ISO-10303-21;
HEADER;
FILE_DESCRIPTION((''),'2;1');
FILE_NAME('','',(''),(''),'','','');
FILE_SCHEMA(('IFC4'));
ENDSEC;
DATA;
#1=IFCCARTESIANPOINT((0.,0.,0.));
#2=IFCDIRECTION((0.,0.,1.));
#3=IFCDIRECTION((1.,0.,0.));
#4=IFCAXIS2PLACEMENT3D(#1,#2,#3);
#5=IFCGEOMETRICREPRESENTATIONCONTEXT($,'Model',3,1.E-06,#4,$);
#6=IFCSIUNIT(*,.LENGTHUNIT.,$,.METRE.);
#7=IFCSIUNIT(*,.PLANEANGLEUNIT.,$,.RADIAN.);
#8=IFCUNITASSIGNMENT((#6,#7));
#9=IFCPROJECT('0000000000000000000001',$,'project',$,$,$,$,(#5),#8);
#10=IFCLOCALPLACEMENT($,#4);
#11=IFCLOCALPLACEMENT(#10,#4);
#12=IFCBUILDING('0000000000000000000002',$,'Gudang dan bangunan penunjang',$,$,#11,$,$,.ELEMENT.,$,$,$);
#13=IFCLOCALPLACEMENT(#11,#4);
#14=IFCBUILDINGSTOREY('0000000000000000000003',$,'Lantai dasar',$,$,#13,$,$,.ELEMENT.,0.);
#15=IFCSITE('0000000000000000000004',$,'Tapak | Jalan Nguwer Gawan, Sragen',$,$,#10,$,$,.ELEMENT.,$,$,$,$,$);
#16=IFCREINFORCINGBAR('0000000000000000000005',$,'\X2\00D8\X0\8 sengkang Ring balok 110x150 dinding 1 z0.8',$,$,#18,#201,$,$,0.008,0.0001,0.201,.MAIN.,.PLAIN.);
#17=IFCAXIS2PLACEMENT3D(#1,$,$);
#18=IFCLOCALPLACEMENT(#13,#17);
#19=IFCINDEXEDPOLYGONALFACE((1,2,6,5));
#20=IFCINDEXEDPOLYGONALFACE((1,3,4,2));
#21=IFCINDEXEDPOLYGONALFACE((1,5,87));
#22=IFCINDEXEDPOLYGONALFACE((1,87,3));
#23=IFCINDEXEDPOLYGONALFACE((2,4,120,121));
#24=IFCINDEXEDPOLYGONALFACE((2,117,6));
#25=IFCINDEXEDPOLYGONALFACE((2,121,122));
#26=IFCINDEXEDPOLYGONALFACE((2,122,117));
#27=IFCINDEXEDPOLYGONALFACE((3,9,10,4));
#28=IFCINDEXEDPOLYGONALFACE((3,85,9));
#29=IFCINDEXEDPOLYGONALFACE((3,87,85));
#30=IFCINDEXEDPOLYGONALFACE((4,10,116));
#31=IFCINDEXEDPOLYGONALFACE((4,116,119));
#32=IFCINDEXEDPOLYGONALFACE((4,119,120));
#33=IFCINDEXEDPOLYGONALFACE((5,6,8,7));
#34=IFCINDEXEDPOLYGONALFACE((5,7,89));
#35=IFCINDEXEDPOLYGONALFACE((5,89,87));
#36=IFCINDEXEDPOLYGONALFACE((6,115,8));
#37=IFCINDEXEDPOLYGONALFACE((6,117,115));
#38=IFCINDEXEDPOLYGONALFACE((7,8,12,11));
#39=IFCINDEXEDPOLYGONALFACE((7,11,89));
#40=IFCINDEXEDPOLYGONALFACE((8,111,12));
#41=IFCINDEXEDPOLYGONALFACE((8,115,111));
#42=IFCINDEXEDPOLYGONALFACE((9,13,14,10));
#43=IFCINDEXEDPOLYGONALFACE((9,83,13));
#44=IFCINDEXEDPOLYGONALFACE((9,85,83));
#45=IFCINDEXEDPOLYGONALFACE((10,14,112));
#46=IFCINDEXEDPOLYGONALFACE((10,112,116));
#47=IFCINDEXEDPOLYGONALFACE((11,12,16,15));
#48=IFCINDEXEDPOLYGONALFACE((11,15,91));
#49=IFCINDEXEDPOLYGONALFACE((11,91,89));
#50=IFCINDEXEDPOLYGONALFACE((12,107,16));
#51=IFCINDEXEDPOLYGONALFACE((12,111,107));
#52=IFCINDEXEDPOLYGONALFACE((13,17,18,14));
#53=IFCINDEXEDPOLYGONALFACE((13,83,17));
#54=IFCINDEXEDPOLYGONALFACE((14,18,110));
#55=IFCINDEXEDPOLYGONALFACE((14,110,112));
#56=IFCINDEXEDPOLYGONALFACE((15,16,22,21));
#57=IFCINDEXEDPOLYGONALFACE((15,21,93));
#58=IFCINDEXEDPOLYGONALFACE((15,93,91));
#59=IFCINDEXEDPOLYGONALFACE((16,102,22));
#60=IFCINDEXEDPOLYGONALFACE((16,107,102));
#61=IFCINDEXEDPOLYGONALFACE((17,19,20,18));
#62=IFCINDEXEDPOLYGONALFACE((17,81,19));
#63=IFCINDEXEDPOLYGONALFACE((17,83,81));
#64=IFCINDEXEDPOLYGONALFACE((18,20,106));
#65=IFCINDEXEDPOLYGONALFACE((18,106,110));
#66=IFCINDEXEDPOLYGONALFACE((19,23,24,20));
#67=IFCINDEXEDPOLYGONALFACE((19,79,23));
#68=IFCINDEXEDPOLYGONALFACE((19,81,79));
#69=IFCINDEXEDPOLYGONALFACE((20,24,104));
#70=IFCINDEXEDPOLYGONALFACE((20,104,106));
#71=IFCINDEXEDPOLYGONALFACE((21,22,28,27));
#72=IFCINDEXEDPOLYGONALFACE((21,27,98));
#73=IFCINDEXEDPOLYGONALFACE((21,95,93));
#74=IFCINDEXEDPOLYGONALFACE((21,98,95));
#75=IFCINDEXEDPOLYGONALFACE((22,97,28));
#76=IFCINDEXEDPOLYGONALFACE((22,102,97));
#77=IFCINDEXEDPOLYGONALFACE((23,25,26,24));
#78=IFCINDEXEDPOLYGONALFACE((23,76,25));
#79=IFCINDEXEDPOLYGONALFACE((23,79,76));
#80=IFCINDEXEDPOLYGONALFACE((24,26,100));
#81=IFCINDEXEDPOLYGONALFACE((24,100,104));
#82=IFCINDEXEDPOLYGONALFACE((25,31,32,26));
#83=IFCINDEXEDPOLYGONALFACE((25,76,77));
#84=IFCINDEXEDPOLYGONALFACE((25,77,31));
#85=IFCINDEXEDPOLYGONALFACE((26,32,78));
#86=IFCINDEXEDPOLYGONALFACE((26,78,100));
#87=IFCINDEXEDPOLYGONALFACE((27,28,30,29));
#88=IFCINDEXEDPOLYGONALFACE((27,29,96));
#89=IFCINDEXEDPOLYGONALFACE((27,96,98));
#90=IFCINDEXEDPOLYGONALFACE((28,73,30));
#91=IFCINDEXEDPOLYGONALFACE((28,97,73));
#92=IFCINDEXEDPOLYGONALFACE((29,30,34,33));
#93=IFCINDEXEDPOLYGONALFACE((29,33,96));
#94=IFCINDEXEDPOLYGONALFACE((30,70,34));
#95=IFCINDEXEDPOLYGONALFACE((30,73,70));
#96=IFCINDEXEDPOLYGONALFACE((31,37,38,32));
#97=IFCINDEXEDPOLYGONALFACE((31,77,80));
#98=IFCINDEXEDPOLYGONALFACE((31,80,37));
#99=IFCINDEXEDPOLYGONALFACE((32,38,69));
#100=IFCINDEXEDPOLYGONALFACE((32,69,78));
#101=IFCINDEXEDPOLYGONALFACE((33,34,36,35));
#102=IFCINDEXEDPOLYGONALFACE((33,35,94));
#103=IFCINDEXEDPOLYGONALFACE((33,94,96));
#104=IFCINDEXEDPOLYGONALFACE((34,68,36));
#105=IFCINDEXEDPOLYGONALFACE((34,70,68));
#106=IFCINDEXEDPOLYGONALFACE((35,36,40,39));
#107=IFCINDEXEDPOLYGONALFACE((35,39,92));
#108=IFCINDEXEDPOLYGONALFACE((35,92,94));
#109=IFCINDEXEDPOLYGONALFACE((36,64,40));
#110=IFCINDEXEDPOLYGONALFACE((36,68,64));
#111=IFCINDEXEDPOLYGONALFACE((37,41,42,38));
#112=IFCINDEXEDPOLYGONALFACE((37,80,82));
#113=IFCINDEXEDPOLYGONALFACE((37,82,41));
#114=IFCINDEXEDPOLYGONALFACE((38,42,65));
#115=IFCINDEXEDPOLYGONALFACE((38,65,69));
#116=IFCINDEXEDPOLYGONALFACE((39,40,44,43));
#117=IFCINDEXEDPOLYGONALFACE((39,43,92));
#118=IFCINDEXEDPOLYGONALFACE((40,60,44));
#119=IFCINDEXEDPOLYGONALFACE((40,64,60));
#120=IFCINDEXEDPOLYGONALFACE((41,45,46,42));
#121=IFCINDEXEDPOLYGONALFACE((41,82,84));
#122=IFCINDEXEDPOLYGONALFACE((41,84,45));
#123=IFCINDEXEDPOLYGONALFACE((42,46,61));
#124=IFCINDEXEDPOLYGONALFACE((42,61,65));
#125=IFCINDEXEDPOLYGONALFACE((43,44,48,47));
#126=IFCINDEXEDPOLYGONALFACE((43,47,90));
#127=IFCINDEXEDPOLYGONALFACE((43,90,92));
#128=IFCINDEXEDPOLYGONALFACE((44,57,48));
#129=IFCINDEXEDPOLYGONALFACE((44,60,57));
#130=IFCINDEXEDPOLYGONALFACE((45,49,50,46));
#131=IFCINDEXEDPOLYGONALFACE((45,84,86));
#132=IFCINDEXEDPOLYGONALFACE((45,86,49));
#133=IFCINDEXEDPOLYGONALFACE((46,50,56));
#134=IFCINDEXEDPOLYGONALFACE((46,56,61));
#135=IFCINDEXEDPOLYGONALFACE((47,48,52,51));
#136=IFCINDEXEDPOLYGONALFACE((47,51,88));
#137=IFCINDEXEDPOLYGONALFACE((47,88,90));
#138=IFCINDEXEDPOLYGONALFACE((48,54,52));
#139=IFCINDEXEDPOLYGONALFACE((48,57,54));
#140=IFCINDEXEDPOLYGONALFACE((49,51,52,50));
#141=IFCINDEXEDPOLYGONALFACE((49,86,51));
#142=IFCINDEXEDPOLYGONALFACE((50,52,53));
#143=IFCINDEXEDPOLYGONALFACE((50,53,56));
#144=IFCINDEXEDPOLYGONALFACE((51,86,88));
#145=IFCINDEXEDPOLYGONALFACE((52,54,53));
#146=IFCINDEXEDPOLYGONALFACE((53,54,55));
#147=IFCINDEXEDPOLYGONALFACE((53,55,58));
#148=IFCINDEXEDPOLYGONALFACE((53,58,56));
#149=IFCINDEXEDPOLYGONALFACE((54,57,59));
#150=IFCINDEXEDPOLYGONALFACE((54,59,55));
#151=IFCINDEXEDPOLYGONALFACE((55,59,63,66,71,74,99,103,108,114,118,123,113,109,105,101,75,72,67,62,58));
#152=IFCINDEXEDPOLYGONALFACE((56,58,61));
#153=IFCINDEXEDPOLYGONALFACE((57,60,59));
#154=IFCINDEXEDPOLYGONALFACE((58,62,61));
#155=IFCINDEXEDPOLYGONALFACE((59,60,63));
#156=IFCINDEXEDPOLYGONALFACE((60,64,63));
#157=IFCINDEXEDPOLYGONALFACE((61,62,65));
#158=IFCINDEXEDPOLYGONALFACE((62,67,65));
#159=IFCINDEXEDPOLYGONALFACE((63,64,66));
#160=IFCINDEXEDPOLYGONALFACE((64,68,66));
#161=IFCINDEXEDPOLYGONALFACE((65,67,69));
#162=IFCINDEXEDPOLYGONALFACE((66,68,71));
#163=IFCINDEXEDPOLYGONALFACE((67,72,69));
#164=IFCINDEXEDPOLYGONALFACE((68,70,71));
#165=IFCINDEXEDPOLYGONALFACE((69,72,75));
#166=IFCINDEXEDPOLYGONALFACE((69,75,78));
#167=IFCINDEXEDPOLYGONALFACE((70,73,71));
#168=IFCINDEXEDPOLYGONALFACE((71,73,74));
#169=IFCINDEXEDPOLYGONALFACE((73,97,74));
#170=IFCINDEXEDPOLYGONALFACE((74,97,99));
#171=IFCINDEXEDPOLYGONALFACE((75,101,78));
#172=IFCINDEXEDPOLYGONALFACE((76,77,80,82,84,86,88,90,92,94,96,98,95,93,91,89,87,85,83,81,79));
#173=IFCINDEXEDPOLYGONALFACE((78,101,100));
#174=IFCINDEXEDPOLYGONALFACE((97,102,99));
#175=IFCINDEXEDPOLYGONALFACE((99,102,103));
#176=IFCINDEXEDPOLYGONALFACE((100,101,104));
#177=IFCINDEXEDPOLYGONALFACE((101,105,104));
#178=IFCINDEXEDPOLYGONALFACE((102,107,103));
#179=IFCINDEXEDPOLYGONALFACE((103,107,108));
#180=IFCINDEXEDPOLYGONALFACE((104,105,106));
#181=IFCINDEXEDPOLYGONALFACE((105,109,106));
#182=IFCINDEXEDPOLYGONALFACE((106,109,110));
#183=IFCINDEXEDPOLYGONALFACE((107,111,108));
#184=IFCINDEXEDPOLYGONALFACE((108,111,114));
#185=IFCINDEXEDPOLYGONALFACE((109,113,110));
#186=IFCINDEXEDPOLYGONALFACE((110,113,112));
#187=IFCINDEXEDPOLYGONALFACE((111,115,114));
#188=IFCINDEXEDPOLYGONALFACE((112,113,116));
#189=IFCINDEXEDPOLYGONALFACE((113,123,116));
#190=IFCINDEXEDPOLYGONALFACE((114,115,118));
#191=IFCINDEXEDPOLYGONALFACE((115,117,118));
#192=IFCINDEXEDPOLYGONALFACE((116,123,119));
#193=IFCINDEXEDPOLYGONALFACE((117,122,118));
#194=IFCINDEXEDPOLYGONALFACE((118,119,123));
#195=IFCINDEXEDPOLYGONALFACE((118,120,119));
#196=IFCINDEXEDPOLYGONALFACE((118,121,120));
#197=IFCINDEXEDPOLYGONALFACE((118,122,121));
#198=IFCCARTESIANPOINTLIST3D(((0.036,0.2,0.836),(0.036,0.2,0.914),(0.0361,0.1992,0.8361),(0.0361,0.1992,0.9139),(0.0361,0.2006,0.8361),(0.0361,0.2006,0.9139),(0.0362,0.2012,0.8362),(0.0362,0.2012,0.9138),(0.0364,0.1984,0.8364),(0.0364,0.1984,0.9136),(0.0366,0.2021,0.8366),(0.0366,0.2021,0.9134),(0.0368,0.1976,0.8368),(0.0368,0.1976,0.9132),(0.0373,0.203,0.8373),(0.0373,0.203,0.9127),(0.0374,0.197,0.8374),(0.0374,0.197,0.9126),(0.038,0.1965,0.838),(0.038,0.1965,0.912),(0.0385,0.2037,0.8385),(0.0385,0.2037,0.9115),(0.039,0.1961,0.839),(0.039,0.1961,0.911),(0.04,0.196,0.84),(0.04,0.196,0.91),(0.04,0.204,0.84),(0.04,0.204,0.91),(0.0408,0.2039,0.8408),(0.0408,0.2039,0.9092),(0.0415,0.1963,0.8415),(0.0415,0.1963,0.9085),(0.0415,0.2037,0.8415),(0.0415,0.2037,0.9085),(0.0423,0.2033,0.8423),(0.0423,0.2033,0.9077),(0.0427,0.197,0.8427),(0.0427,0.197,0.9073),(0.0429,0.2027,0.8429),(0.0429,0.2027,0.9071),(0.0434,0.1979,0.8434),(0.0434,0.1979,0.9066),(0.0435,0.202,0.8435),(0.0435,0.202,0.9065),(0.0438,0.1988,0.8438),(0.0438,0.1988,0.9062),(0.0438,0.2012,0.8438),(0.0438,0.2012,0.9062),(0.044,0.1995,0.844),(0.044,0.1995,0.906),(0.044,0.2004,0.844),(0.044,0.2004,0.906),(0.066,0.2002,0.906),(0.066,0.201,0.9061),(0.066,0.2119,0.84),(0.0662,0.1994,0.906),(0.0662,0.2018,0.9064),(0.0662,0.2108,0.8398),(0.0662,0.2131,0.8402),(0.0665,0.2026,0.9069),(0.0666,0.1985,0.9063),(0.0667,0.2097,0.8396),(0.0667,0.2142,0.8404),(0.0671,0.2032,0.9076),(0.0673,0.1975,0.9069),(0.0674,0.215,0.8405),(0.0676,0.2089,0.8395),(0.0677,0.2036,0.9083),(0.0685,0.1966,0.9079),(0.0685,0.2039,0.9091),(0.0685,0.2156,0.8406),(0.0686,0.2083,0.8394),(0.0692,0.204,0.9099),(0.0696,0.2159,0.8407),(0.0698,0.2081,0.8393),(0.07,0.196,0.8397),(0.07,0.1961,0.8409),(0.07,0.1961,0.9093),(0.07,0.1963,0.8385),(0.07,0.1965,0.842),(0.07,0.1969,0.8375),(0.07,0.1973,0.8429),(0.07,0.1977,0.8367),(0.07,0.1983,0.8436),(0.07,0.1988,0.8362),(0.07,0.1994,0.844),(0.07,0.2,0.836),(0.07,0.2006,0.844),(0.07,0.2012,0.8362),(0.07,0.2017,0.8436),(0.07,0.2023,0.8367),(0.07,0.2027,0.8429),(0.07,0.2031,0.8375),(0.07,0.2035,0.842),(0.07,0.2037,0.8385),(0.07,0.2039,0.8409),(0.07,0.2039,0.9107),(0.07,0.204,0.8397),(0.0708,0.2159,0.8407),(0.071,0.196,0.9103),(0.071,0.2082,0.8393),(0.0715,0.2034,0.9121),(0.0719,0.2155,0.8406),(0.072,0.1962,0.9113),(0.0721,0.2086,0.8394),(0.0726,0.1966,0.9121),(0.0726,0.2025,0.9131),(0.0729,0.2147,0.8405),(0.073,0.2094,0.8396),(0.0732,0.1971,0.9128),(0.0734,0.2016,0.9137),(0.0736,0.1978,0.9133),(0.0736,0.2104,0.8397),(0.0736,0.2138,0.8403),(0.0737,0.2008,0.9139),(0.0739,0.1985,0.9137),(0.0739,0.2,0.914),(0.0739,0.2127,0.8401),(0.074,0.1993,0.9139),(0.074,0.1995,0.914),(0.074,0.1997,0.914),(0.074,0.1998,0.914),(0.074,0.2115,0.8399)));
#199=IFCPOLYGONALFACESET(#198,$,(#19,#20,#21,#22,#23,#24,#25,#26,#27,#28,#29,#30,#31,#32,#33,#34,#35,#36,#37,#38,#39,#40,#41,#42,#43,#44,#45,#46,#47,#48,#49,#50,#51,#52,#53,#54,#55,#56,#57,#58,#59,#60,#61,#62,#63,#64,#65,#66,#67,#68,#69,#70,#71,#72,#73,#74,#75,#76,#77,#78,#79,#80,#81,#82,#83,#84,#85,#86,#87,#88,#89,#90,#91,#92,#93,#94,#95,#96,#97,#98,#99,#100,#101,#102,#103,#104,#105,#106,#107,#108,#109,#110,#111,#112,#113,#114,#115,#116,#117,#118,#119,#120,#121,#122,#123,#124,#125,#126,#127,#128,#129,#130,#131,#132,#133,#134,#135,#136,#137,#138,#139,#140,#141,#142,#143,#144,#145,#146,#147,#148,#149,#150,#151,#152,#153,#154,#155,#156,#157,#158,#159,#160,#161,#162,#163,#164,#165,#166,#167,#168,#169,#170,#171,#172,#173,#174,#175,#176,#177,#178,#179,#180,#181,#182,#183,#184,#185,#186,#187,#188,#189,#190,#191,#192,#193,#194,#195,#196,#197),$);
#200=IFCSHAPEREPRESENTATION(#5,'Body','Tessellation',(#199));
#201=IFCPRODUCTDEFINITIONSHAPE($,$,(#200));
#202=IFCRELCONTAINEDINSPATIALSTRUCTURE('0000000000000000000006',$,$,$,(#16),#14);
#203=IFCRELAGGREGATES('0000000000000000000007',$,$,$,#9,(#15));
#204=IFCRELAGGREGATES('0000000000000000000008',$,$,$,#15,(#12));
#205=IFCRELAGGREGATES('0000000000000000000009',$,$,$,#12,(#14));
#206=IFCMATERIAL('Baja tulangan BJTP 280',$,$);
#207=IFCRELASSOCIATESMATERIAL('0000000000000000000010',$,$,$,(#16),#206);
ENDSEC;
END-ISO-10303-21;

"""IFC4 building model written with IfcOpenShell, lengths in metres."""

from ifc_helpers import new_model, entity, si_unit, origin_with_axes, place, context, project, spatial, material, element, save


model = new_model("IFC4")

# Units and contexts
model_context = context("Model", 3, precision=1e-06, world=origin_with_axes())
ifc_project = project(units=[si_unit("LENGTHUNIT", "METRE"), si_unit("PLANEANGLEUNIT", "RADIAN")], contexts=[model_context])

# Site, building, storey
site_placement = place(None, origin_with_axes())
site = spatial("IfcSite", under=ifc_project, at=site_placement, Name="Tapak | Jalan Nguwer Gawan, Sragen", CompositionType="ELEMENT")
building_placement = place(site_placement, origin_with_axes())
building = spatial("IfcBuilding", under=site, at=building_placement, Name="Gudang dan bangunan penunjang", CompositionType="ELEMENT")
storey_placement = place(building_placement, origin_with_axes())
storey = spatial("IfcBuildingStorey", under=building, at=storey_placement, Name="Lantai dasar", CompositionType="ELEMENT", Elevation=0.0)

# Shared definitions
placement = place(None, origin_with_axes())

# Reinforcing bar
ifc_material_1 = material(Name="Baja tulangan BJTP 280")
element("IfcReinforcingBar", 1, at=placement, inside=storey, material=ifc_material_1, Name="Ø8 sengkang Ring balok 110x150 dinding 1 z0.8", BarLength=0.201, BarSurface="PLAIN", CrossSectionArea=0.0001, NominalDiameter=0.008, PredefinedType="MAIN", context=model_context, shape_type="AdvancedSweptSolid", body=[
    entity("IfcSweptDiskSolid", entity("IfcPolyline", [entity("IfcCartesianPoint", [0.07, 0.2, 0.84]), entity("IfcCartesianPoint", [0.04, 0.2, 0.84]), entity("IfcCartesianPoint", [0.04, 0.2, 0.91]), entity("IfcCartesianPoint", [0.07, 0.2, 0.91]), entity("IfcCartesianPoint", [0.07, 0.212, 0.84])]), 0.004),
])

save(model, "model.ifc")
